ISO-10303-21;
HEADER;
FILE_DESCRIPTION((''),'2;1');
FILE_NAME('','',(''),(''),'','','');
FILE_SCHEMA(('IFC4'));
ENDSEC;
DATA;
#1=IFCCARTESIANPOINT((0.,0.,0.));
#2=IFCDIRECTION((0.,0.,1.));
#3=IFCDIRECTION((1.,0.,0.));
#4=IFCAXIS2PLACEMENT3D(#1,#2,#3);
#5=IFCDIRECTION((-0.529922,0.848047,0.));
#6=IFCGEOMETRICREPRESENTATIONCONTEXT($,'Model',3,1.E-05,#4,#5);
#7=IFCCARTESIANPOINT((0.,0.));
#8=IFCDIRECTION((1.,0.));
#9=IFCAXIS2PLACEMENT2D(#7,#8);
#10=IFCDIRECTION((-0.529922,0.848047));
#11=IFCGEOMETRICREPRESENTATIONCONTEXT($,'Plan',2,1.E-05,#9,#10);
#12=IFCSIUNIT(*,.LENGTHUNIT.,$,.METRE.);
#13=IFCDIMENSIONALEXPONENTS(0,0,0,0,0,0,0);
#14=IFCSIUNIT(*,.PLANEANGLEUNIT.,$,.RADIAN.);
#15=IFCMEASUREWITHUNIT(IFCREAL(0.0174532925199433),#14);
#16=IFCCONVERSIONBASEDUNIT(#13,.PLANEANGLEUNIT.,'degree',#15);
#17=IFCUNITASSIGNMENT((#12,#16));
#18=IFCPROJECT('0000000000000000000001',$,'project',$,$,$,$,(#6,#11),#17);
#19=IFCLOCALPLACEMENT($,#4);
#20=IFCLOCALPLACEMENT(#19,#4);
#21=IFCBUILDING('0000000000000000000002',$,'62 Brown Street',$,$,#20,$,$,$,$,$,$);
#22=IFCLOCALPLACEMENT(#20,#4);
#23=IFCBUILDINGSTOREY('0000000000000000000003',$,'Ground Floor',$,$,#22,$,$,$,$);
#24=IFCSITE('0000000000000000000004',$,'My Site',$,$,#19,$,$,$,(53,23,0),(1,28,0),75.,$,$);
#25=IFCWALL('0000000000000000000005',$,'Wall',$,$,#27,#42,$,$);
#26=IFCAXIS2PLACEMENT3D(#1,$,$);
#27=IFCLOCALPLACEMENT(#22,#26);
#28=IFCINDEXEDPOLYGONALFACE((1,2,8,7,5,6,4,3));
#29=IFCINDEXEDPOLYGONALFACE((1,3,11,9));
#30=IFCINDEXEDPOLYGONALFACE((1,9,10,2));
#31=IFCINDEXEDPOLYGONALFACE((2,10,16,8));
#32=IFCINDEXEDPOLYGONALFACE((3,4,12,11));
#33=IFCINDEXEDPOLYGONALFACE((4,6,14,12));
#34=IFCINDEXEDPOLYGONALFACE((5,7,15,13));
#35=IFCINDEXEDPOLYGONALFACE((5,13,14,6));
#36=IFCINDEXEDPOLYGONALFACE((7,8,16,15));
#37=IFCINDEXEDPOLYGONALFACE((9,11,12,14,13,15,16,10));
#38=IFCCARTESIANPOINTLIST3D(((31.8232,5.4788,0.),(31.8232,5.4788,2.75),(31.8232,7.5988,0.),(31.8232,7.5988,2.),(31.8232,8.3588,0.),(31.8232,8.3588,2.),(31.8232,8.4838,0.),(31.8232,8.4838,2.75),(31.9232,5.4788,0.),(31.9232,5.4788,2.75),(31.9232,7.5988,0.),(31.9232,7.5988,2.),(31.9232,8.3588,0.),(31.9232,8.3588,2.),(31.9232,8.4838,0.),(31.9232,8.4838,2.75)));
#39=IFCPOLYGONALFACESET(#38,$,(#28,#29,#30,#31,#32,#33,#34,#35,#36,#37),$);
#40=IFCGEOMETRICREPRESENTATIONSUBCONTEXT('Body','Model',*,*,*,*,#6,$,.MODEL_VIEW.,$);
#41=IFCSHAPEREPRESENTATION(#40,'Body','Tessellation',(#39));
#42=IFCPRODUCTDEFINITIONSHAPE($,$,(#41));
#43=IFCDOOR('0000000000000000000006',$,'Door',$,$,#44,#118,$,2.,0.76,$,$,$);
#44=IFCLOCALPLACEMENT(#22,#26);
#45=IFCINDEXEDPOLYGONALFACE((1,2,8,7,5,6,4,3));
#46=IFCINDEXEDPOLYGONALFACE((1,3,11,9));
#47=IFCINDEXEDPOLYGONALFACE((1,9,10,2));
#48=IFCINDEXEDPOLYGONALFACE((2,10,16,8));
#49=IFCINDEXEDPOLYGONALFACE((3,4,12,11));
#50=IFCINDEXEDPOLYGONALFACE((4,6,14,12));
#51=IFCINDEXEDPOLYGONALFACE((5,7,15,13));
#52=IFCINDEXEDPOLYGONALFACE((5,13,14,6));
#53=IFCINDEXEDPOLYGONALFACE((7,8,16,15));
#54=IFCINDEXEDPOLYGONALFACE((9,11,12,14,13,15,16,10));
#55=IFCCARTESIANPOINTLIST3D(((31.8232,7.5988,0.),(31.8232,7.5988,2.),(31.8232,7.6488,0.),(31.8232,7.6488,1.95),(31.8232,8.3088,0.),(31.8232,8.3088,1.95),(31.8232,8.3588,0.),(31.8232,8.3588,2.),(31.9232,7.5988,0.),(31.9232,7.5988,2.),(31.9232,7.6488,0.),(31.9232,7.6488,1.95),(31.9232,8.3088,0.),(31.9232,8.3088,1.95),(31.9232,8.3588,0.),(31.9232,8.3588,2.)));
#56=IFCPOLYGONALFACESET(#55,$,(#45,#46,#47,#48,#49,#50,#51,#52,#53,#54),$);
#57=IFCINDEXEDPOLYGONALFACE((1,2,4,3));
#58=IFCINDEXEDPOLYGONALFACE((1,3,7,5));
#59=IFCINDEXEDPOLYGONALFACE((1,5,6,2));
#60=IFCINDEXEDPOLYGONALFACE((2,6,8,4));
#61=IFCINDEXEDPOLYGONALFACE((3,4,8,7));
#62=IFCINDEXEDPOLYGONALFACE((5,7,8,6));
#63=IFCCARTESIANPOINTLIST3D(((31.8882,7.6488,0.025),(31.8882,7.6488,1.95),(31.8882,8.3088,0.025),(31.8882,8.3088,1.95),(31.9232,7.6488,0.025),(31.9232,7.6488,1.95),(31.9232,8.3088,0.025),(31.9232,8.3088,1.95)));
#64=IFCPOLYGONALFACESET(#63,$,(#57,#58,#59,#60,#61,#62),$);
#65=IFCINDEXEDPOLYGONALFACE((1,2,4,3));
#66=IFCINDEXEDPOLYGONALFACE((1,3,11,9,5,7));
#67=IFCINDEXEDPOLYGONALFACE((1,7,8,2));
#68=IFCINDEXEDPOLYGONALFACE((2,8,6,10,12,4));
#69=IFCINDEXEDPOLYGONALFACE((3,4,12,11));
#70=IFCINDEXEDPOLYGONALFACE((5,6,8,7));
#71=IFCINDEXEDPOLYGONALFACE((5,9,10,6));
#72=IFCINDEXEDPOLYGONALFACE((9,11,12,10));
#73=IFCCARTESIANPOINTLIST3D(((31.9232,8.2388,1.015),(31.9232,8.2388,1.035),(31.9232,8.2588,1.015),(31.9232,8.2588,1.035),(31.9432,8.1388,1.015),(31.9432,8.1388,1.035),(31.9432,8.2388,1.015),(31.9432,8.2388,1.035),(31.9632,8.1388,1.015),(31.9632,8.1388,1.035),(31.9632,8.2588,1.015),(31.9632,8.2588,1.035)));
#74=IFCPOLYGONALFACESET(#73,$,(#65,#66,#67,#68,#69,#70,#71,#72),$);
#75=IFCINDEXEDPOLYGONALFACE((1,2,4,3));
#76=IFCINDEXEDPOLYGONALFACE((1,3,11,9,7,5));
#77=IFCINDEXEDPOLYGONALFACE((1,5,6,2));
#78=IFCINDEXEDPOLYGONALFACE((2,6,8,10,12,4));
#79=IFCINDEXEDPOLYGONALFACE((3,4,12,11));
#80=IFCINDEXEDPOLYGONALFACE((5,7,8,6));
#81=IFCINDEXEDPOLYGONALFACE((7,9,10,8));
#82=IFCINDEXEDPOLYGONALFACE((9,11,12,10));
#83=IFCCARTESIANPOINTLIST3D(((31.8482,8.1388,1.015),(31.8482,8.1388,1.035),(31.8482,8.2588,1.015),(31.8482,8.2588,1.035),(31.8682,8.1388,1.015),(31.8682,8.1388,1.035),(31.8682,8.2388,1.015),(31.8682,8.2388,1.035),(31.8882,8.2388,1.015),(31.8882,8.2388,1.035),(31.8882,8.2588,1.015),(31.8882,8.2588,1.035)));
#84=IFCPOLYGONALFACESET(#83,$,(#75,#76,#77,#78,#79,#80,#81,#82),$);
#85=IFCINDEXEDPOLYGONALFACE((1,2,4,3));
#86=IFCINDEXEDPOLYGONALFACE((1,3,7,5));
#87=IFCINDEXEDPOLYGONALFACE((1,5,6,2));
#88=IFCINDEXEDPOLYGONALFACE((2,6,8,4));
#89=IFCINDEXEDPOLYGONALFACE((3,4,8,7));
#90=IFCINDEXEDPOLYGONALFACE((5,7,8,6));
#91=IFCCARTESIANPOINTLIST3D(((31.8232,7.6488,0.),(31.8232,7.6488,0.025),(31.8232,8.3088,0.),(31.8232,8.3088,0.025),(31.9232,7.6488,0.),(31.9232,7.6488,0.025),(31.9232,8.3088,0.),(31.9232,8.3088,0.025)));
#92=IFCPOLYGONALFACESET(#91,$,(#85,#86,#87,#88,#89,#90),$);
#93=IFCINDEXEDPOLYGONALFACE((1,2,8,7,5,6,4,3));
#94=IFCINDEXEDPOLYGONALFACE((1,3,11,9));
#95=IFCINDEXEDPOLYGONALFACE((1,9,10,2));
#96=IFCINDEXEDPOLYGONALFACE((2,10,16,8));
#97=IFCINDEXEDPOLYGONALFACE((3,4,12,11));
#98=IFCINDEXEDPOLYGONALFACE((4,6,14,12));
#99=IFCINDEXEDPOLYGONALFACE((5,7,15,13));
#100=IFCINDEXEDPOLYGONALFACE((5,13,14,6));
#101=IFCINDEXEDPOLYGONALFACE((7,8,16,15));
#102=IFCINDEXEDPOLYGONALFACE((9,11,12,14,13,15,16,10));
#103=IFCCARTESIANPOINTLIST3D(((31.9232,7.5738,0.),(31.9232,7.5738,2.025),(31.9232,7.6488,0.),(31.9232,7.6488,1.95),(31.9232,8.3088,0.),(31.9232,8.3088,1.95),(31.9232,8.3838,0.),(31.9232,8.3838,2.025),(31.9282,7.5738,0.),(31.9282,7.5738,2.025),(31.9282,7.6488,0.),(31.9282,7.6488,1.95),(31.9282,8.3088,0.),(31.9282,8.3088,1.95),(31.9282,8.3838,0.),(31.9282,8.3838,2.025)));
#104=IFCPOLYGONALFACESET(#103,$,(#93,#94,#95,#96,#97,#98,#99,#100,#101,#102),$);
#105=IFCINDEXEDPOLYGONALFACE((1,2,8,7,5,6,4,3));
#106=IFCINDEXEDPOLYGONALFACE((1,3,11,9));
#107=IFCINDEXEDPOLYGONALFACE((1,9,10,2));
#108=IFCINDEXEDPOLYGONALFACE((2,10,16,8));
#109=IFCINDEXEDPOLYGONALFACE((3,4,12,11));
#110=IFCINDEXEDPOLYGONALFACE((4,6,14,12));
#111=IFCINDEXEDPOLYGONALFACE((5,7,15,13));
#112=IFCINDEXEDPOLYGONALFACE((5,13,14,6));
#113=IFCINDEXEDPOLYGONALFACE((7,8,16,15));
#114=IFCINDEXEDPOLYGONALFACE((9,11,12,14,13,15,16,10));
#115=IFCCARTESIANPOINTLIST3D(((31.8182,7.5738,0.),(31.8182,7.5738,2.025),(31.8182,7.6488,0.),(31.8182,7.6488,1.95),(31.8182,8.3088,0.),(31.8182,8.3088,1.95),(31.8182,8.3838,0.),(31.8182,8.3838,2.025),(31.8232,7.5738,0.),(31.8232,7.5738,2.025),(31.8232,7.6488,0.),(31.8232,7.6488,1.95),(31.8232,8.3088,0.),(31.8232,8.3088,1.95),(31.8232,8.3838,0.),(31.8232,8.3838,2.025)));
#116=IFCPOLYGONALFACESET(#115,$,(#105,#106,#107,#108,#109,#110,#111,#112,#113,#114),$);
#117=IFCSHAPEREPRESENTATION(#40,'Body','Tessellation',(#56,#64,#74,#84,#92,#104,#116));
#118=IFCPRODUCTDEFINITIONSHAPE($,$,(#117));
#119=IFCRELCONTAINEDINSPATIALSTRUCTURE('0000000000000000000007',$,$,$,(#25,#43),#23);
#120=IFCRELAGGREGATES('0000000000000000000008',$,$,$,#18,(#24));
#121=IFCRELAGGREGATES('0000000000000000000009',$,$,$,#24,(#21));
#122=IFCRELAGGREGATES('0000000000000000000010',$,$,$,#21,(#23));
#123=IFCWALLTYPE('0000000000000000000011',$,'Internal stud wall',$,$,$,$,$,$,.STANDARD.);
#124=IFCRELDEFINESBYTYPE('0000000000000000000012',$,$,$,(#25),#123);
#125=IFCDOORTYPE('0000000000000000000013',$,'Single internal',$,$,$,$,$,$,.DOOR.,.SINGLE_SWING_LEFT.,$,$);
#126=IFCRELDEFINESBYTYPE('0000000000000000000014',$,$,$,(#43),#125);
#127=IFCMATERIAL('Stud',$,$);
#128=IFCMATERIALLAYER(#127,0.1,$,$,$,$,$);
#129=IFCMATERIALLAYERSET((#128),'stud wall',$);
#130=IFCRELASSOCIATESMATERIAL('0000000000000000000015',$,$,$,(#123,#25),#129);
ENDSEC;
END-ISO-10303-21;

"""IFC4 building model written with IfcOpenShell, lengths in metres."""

from ifc_helpers import new_model, entity, si_unit, converted_unit, direction, frame, origin_with_axes, origin_2d_with_axis, place, context, subcontext, project, spatial, line, indexed_curve, outline, extrude, shape, source, transform, mapped, material, layer, layer_set, layer_usage, type_object, type_shapes, element, fill, save


model = new_model("IFC4")

# Units and contexts
model_context = context("Model", 3, precision=1e-05, world=origin_with_axes(), true_north=direction((-0.529922, 0.848047, 0.0)))
plan_context = context("Plan", 2, precision=1e-05, world=origin_2d_with_axis(), true_north=direction((-0.529922, 0.848047)))
body_context_1 = subcontext(model_context, "Body", "Model", "MODEL_VIEW")
body_context_2 = subcontext(plan_context, "Body", "Plan", "PLAN_VIEW")
ifc_project = project(units=[si_unit("LENGTHUNIT", "METRE"), converted_unit("PLANEANGLEUNIT", "degree", entity("IfcReal", 0.0174532925199433), si_unit("PLANEANGLEUNIT", "RADIAN"), dimensions=[0, 0, 0, 0, 0, 0, 0])], contexts=[model_context, plan_context])

# Site, building, storey
site_placement = place(None, origin_with_axes())
site = spatial("IfcSite", under=ifc_project, at=site_placement, Name="My Site", RefLatitude=(53, 23, 0), RefLongitude=(1, 28, 0), RefElevation=75.0)
building_placement = place(site_placement, origin_with_axes())
building = spatial("IfcBuilding", under=site, at=building_placement, Name="62 Brown Street")
storey_placement = place(building_placement, origin_with_axes())
storey = spatial("IfcBuildingStorey", under=building, at=storey_placement, Name="Ground Floor")

# Wall, opening, door
ifc_material_1 = material(Name="Stud")
ifc_layer_1 = layer(ifc_material_1, 0.1)
ifc_layer_set_1 = layer_set([ifc_layer_1], Name="stud wall")
wall_type_1 = type_object("IfcWallType", Name="Internal stud wall", PredefinedType="STANDARD", material=ifc_layer_set_1)
shared_shape_1 = source(origin_with_axes(), body_context_1, "Body", "SweptSolid", [
    extrude(outline(indexed_curve([(0.0, 0.0), (0.76, 0.0), (0.76, 2.0), (0.0, 2.0)], segments=[line(1, 2, 3, 4, 1)])), frame((0.0, -0.6, 0.0), z_axis=(0.0, -1.0, 0.0), x_axis=(1.0, 0.0, 0.0)), (0.0, 0.0, -1.0), 1.2),
])
door_type_1 = type_object("IfcDoorType", Name="Single internal", OperationType="SINGLE_SWING_LEFT", PredefinedType="DOOR")
shared_shape_2 = source(origin_with_axes(), body_context_1, "Body", "SweptSolid", [
    extrude(outline(indexed_curve([(0.0, 0.0), (0.0, 2.0), (0.76, 2.0), (0.76, 0.0), (0.71, 0.0), (0.71, 1.95), (0.05, 1.95), (0.05, 0.0)], segments=[line(1, 2, 3, 4, 5, 6, 7, 8, 1)])), frame((0.0, 0.0, 0.0), z_axis=(0.0, -1.0, 0.0), x_axis=(1.0, 0.0, 0.0)), (0.0, 0.0, -1.0), 0.1),
    extrude(outline(indexed_curve([(0.0, 0.0), (0.66, 0.0), (0.66, 0.035), (0.0, 0.035)], segments=[line(1, 2, 3, 4, 1)])), frame((0.05, 0.0, 0.025), z_axis=(0.0, 0.0, 1.0), x_axis=(1.0, 0.0, 0.0)), (0.0, 0.0, 1.0), 1.925),
    extrude(outline(indexed_curve([(0.0, 0.0), (0.0, -0.04), (-0.12, -0.04), (-0.12, -0.02), (-0.02, -0.02), (-0.02, 0.0)], segments=[line(1, 2, 3, 4, 5, 6, 1)])), frame((0.66, 0.0, 1.015), z_axis=(0.0, 0.0, 1.0), x_axis=(1.0, 0.0, 0.0)), (0.0, 0.0, 1.0), 0.02),
    extrude(outline(indexed_curve([(0.0, 0.0), (0.0, 0.04), (-0.12, 0.04), (-0.12, 0.02), (-0.02, 0.02), (-0.02, 0.0)], segments=[line(1, 2, 3, 4, 5, 6, 1)])), frame((0.66, 0.035, 1.015), z_axis=(0.0, 0.0, 1.0), x_axis=(1.0, 0.0, 0.0)), (0.0, 0.0, 1.0), 0.02),
    extrude(outline(indexed_curve([(0.0, 0.0), (0.66, 0.0), (0.66, 0.1), (0.0, 0.1)], segments=[line(1, 2, 3, 4, 1)])), frame((0.05, 0.0, 0.0), z_axis=(0.0, 0.0, 1.0), x_axis=(1.0, 0.0, 0.0)), (0.0, 0.0, 1.0), 0.025),
    extrude(outline(indexed_curve([(0.0, 0.0), (0.0, 2.025), (0.81, 2.025), (0.81, 0.0), (0.735, 0.0), (0.735, 1.95), (0.075, 1.95), (0.075, 0.0)], segments=[line(1, 2, 3, 4, 5, 6, 7, 8, 1)])), frame((-0.025, -0.005, 0.0), z_axis=(0.0, -1.0, 0.0), x_axis=(1.0, 0.0, 0.0)), (0.0, 0.0, -1.0), 0.005),
    extrude(outline(indexed_curve([(0.0, 0.0), (0.0, 2.025), (0.81, 2.025), (0.81, 0.0), (0.735, 0.0), (0.735, 1.95), (0.075, 1.95), (0.075, 0.0)], segments=[line(1, 2, 3, 4, 5, 6, 7, 8, 1)])), frame((-0.025, 0.1, 0.0), z_axis=(0.0, -1.0, 0.0), x_axis=(1.0, 0.0, 0.0)), (0.0, 0.0, -1.0), 0.005),
])
shared_shape_3 = source(origin_with_axes(), body_context_2, "Body", "Curve2D", [
    entity("IfcIndexedPolyCurve", entity("IfcCartesianPointList2D", [[0.0, 0.0], [0.05, 0.0], [0.05, 0.1], [0.0, 0.1]]), [entity("IfcLineIndex", [1, 2, 3, 4, 1])]),
    entity("IfcIndexedPolyCurve", entity("IfcCartesianPointList2D", [[0.76, 0.0], [0.71, 0.0], [0.71, 0.1], [0.76, 0.1]]), [entity("IfcLineIndex", [1, 2, 3, 4, 1])]),
    entity("IfcTrimmedCurve", entity("IfcEllipse", entity("IfcAxis2Placement2D", entity("IfcCartesianPoint", [0.085, 0.1]), entity("IfcDirection", [1.0, 0.0])), 0.625, 0.66), [entity("IfcCartesianPoint", [0.71, 0.1])], [entity("IfcCartesianPoint", [0.085, 0.76])], True, "CARTESIAN"),
    entity("IfcIndexedPolyCurve", entity("IfcCartesianPointList2D", [[0.05, 0.1], [0.085, 0.1], [0.085, 0.76], [0.05, 0.76]]), [entity("IfcLineIndex", [1, 2, 3, 4, 1])]),
])
type_shapes(door_type_1, [shared_shape_2, shared_shape_3])
ifc_layer_usage_1 = layer_usage(ifc_layer_set_1, "AXIS2", "POSITIVE", 0.0)
wall_1_placement = place(storey_placement, frame((31.9232, 5.4788, 0.0), z_axis=(0.0, 0.0, 1.0), x_axis=(0.000001, 1.0, 0.0)))
wall_1 = element("IfcWall", 1, at=wall_1_placement, inside=storey, type_object=wall_type_1, material=ifc_layer_usage_1, Name="Wall", context=body_context_1, shape_type="SweptSolid", body=[
    extrude(outline(indexed_curve([(0.0, 0.0), (0.0, 0.1), (3.005, 0.1), (3.005, 0.0), (0.0, 0.0)], self_intersect=False)), origin_with_axes(), (0.0, 0.0, 1.0), 2.75),
])
opening_1_placement = place(wall_1_placement, frame((2.12, 0.0, 0.0), z_axis=(0.0, 0.0, 1.0), x_axis=(1.0, 0.0, 0.0)))
opening_1 = element("IfcOpeningElement", 2, at=opening_1_placement, cuts=wall_1, PredefinedType="OPENING", context=body_context_1, shape_type="MappedRepresentation", body=[
    mapped(shared_shape_1, transform((0.0, 0.0, 0.0), x_axis=(1.0, 0.0, 0.0), y_axis=(0.0, 1.0, 0.0), z_axis=(0.0, 0.0, 1.0), scale=1.0)),
])
door_1_placement = place(opening_1_placement, frame((0.0, 0.0, 0.0), z_axis=(0.0, 0.0, 1.0), x_axis=(1.0, 0.0, 0.0)))
door_1 = element("IfcDoor", 3, at=door_1_placement, inside=storey, type_object=door_type_1, Name="Door", OverallHeight=2.0, OverallWidth=0.76, shapes=[
    shape(body_context_1, "Body", "MappedRepresentation", [mapped(shared_shape_2, transform((0.0, 0.0, 0.0), x_axis=(1.0, 0.0, 0.0), y_axis=(0.0, 1.0, 0.0), z_axis=(0.0, 0.0, 1.0), scale=1.0))]),
    shape(body_context_2, "Body", "MappedRepresentation", [mapped(shared_shape_3, transform((0.0, 0.0, 0.0), x_axis=(1.0, 0.0, 0.0), y_axis=(0.0, 1.0, 0.0), z_axis=(0.0, 0.0, 1.0), scale=1.0))]),
])
fill(opening_1, door_1)

save(model, "model.ifc")
